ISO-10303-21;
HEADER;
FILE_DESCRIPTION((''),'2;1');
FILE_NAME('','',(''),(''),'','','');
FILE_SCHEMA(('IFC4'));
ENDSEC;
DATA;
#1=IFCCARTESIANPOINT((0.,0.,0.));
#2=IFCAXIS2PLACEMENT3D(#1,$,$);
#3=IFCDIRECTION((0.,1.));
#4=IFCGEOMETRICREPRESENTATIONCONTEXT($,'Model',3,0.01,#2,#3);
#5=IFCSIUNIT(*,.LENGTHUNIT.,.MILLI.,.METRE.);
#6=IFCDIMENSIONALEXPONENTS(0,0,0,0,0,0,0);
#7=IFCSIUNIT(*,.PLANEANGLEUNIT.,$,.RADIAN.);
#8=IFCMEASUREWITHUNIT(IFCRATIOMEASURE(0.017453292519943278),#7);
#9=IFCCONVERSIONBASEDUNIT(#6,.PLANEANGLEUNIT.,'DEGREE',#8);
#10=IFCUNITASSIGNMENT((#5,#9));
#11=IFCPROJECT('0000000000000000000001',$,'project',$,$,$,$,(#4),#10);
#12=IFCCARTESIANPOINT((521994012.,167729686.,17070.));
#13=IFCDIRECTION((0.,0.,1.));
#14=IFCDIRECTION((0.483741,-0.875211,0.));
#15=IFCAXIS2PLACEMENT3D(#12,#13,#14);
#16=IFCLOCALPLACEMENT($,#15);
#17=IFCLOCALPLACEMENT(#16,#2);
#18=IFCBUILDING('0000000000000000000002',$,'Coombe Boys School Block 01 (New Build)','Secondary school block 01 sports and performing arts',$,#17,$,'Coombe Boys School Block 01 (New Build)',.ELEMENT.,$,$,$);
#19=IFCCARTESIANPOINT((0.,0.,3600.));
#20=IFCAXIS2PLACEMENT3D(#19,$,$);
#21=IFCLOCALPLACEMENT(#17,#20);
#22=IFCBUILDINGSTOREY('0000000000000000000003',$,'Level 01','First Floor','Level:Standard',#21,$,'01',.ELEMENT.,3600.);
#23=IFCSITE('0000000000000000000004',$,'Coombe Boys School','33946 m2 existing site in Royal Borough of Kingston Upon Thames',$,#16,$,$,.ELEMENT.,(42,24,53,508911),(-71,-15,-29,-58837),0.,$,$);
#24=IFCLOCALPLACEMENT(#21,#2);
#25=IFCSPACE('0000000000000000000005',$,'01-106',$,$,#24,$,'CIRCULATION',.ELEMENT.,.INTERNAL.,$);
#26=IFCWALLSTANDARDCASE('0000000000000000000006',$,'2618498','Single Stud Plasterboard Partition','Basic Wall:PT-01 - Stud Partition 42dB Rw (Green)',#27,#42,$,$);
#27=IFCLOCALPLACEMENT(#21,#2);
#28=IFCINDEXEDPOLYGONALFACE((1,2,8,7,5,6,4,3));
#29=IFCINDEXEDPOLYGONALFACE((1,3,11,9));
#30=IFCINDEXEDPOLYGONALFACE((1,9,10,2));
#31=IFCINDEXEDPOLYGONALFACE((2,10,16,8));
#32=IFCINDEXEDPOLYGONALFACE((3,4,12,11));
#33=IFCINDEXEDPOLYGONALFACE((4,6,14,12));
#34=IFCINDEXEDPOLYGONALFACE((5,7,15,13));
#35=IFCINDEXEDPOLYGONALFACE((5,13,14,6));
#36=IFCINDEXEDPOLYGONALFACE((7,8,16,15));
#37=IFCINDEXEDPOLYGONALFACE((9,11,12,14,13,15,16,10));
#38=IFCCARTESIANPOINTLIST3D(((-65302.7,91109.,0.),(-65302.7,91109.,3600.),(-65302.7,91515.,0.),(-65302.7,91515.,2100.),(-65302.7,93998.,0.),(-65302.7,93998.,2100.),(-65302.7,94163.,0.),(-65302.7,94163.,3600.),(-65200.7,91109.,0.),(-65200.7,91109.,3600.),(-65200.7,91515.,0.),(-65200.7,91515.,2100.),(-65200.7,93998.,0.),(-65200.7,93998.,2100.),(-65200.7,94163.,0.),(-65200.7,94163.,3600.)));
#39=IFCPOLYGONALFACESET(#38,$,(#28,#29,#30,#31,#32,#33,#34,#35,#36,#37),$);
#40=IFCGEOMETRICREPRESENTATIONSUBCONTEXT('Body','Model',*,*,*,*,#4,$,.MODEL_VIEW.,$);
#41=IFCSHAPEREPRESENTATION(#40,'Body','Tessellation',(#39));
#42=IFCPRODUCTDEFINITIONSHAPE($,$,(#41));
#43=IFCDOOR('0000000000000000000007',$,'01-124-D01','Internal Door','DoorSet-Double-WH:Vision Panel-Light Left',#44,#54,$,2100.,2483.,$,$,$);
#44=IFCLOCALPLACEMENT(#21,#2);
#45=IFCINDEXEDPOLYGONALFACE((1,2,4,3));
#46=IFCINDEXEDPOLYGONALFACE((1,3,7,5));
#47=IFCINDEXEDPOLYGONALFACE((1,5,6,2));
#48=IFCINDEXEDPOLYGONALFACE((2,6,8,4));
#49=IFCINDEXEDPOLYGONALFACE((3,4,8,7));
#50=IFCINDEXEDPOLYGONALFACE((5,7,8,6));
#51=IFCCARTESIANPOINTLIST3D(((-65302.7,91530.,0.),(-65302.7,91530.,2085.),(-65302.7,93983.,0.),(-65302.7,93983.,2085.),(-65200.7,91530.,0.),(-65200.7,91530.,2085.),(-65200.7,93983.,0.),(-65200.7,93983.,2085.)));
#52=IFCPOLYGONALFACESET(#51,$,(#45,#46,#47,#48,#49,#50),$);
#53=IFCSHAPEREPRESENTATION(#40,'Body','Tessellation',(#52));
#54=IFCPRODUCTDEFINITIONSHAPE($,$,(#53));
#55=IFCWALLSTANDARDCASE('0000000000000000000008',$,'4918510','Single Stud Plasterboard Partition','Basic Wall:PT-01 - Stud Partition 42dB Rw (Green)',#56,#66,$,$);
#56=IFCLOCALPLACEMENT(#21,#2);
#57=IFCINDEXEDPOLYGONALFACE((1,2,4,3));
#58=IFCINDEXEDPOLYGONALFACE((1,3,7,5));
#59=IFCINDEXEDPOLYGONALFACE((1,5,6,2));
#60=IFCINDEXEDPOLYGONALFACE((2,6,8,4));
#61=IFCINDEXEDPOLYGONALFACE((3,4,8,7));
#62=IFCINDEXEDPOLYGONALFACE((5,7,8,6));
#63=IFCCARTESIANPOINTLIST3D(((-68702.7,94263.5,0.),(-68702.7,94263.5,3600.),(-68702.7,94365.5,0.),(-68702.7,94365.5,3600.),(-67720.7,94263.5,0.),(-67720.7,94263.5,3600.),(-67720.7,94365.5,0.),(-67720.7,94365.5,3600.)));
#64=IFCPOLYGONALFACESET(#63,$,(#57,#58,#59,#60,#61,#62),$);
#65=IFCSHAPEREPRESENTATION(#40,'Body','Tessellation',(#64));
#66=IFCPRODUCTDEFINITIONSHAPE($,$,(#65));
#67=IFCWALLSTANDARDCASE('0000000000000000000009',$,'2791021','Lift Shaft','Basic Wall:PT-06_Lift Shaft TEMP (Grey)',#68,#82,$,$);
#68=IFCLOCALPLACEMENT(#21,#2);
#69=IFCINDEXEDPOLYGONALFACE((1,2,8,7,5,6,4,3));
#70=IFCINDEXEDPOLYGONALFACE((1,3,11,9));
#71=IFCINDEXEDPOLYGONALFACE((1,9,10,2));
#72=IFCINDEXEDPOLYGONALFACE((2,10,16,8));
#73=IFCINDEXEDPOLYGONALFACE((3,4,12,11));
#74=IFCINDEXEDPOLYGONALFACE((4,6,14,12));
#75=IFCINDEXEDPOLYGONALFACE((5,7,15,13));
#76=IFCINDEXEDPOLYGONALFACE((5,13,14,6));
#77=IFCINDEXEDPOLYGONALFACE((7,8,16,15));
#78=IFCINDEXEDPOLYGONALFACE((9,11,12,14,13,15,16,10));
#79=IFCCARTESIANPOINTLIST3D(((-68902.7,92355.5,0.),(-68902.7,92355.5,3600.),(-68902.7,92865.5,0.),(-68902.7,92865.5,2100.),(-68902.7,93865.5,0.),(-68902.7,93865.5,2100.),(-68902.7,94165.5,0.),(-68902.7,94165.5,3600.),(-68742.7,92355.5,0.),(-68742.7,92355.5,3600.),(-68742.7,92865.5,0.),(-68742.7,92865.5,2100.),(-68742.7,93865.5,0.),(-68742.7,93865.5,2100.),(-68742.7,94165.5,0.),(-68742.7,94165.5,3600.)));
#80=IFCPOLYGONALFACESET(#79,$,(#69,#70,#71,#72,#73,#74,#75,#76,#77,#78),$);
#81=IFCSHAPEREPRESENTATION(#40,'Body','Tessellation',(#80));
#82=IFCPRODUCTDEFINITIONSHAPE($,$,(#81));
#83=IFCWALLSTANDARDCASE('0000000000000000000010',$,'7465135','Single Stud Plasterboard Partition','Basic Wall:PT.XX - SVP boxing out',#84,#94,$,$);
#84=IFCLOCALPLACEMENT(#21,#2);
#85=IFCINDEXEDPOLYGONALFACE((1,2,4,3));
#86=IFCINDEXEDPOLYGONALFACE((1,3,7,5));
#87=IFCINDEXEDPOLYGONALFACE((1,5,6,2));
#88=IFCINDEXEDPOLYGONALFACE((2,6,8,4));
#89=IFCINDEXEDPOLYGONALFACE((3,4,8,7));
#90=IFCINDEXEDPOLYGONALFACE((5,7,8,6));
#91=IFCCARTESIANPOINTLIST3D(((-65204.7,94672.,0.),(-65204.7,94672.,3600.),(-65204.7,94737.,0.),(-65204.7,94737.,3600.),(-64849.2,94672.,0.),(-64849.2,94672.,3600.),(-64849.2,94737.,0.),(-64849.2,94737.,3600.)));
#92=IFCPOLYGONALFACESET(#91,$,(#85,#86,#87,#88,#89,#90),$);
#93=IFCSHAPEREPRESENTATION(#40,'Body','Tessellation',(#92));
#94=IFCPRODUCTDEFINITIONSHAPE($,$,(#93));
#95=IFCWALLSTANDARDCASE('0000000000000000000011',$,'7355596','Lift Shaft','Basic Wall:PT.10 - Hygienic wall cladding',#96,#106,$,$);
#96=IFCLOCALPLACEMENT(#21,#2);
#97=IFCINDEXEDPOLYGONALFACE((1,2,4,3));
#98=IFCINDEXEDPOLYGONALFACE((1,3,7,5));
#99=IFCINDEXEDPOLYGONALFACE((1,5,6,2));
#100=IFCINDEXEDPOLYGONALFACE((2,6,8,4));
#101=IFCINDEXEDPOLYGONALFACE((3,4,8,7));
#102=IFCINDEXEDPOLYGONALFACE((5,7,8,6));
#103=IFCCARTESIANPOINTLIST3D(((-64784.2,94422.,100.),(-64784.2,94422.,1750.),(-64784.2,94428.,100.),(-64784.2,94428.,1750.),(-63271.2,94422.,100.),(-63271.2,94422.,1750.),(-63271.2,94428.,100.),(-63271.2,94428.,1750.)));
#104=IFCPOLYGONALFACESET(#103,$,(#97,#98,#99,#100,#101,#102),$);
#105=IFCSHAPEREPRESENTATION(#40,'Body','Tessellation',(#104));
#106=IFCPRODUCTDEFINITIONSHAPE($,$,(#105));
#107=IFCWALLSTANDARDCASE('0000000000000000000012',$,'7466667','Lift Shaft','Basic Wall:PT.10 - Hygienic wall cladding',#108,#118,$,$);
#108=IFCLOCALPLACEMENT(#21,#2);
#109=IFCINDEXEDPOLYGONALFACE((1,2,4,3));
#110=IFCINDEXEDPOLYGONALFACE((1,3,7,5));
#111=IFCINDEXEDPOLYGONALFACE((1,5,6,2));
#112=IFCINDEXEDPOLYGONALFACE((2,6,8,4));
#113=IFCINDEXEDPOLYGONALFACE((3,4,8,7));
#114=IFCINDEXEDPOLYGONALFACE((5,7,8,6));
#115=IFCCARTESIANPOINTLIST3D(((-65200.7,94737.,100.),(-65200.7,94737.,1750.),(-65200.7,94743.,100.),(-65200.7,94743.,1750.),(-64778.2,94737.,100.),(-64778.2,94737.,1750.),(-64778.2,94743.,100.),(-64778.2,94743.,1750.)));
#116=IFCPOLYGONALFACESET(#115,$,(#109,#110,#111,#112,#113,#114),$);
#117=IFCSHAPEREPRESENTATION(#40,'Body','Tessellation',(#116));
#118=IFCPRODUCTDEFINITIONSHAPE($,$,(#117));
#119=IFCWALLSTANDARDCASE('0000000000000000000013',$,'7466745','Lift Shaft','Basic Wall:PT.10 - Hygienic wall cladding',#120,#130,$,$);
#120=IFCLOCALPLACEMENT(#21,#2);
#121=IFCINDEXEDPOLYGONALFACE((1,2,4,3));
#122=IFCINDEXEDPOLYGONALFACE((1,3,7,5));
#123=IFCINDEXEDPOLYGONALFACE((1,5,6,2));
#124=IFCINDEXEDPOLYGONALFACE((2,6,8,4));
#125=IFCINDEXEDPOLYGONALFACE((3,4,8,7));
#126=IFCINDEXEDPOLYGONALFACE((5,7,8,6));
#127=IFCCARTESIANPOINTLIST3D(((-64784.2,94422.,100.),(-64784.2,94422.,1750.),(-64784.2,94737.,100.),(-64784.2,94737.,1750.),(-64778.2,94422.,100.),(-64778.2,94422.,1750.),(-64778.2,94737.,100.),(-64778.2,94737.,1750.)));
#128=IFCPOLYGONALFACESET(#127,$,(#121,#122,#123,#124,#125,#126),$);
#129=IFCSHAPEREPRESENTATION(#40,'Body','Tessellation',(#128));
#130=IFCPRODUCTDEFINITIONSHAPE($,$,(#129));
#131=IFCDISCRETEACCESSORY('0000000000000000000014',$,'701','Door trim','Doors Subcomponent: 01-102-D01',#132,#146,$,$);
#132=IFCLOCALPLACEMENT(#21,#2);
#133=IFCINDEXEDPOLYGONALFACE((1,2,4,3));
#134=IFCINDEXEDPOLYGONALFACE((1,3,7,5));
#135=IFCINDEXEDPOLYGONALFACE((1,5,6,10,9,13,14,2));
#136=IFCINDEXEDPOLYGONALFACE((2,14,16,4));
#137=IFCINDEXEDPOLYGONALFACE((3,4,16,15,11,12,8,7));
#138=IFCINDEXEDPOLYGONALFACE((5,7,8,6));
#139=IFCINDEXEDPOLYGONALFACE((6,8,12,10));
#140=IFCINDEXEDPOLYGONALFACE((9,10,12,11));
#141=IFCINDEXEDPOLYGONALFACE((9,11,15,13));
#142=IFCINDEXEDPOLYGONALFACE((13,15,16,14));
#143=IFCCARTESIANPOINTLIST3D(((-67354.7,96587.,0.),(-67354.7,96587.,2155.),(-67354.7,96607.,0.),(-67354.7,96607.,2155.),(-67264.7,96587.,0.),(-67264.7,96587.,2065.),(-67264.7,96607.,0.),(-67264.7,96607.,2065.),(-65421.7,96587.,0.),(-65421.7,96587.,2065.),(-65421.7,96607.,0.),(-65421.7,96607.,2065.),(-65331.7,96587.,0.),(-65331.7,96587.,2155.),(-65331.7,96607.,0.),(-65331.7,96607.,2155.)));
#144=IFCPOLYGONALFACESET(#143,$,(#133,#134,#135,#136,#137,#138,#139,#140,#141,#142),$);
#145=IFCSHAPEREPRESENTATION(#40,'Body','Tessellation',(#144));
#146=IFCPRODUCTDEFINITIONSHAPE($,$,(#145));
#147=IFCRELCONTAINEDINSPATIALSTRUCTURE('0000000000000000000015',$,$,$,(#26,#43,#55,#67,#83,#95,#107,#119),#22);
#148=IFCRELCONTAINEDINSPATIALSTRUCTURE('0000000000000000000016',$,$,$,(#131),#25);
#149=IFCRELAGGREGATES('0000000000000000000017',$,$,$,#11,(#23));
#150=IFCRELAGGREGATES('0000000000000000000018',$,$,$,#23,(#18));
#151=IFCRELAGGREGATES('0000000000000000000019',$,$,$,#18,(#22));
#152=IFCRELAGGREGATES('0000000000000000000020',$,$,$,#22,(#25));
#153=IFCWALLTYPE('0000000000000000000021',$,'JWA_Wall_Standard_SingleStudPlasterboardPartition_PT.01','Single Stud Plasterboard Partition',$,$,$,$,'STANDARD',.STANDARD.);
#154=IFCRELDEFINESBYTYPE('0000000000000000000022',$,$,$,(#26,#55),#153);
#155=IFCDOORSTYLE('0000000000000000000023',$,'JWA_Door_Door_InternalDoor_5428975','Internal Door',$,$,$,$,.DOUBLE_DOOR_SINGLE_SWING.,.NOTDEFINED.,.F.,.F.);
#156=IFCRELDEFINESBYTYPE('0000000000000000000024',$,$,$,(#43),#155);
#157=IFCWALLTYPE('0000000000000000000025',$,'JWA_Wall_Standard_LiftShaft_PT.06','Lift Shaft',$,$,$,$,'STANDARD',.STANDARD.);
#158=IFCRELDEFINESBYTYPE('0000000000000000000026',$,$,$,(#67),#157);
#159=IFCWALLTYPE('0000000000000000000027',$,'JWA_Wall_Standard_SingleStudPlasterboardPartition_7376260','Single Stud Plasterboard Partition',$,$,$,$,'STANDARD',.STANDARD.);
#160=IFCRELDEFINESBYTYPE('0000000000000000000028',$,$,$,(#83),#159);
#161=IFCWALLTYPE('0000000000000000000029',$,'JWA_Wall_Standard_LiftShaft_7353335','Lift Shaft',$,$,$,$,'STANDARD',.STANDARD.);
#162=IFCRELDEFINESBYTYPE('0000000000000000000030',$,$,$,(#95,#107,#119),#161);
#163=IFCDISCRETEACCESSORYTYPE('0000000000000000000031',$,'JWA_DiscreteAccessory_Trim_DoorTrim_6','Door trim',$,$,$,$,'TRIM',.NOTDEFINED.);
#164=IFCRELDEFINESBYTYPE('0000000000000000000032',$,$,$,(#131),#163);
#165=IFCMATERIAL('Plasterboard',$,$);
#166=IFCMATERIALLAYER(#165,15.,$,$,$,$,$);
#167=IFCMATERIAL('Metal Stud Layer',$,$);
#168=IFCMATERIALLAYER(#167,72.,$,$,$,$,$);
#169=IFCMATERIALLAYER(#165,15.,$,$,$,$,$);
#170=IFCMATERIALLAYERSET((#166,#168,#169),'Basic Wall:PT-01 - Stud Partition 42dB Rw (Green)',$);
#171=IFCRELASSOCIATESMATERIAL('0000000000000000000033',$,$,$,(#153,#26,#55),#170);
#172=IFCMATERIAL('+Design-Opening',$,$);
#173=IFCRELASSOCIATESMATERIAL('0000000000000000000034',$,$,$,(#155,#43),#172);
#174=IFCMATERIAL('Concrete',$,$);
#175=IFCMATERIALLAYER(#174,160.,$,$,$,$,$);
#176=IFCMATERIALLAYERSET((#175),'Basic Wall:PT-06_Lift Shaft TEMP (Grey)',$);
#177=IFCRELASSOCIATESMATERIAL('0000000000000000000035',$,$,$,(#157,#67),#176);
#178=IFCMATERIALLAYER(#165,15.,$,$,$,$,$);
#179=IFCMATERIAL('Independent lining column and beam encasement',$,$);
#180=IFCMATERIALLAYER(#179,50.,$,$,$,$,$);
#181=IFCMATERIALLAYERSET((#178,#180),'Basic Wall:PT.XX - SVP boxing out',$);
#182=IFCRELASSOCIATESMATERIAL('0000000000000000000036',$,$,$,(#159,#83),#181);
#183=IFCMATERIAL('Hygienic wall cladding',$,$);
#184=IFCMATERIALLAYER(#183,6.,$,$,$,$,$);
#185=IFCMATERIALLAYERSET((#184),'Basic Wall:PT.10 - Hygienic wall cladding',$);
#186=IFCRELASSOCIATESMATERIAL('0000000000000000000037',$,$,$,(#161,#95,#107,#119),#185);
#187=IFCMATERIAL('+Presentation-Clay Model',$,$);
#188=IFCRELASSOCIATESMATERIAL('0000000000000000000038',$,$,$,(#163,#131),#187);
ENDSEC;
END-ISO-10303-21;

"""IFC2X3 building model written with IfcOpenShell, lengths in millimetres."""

from ifc_helpers import new_model, entity, si_unit, converted_unit, direction, frame, frame_2d, origin, origin_2d_with_axis, place, context, subcontext, project, spatial, polyline, rectangle, outline, extrude, source, transform, mapped, material, layer, layer_set, layer_usage, type_object, type_shapes, element, fill, save


model = new_model("IFC2X3")

# Units and contexts
model_context = context("Model", 3, precision=0.01, world=origin(), true_north=direction((0.0, 1.0)))
body_context = subcontext(model_context, "Body", "Model", "MODEL_VIEW")
ifc_project = project(units=[si_unit("LENGTHUNIT", "METRE", prefix="MILLI"), converted_unit("PLANEANGLEUNIT", "DEGREE", entity("IfcRatioMeasure", 0.017453292519943278), si_unit("PLANEANGLEUNIT", "RADIAN"), dimensions=[0, 0, 0, 0, 0, 0, 0])], contexts=[model_context])

# Site, building, storey
site_placement = place(None, frame((521994012.0, 167729686.0, 17070.0), z_axis=(0.0, 0.0, 1.0), x_axis=(0.483741, -0.875211, 0.0)))
site = spatial("IfcSite", under=ifc_project, at=site_placement, Name="Coombe Boys School", Description="33946 m2 existing site in Royal Borough of Kingston Upon Thames", CompositionType="ELEMENT", RefLatitude=(42, 24, 53, 508911), RefLongitude=(-71, -15, -29, -58837), RefElevation=0.0)
building_placement = place(site_placement, origin())
building = spatial("IfcBuilding", under=site, at=building_placement, Name="Coombe Boys School Block 01 (New Build)", Description="Secondary school block 01 sports and performing arts", LongName="Coombe Boys School Block 01 (New Build)", CompositionType="ELEMENT")
storey_placement = place(building_placement, frame((0.0, 0.0, 3600.0)))
storey = spatial("IfcBuildingStorey", under=building, at=storey_placement, Name="Level 01", Description="First Floor", ObjectType="Level:Standard", LongName="01", CompositionType="ELEMENT", Elevation=3600.0)

# Wall, opening, door
ifc_material_1 = material(Name="Plasterboard")
ifc_layer_1 = layer(ifc_material_1, 15.0)
ifc_material_2 = material(Name="Metal Stud Layer")
ifc_layer_2 = layer(ifc_material_2, 72.0)
ifc_layer_3 = layer(ifc_material_1, 15.0)
ifc_layer_set_1 = layer_set([ifc_layer_1, ifc_layer_2, ifc_layer_3], Name="Basic Wall:PT-01 - Stud Partition 42dB Rw (Green)")
ifc_layer_usage_1 = layer_usage(ifc_layer_set_1, "AXIS2", "NEGATIVE", 51.0)
wall_type_1 = type_object("IfcWallType", Name="JWA_Wall_Standard_SingleStudPlasterboardPartition_PT.01", Description="Single Stud Plasterboard Partition", ElementType="STANDARD", PredefinedType="STANDARD", material=ifc_layer_set_1)
wall_1_placement = place(storey_placement, frame((-65251.7, 94163.0, 0.0), z_axis=(0.0, 0.0, 1.0), x_axis=(0.0, -1.0, 0.0)))
wall_1 = element("IfcWallStandardCase", 1, at=wall_1_placement, inside=storey, type_object=wall_type_1, material=ifc_layer_usage_1, Name="2618498", Description="Single Stud Plasterboard Partition", ObjectType="Basic Wall:PT-01 - Stud Partition 42dB Rw (Green)", context=body_context, shape_type="SweptSolid", body=[
    extrude(rectangle(XDim=3054.0, YDim=102.0, at=frame_2d((1527.0, 0.0), x_axis=(1.0, 0.0))), origin(), (0.0, 0.0, 1.0), 3600.0),
])
opening_1_placement = place(wall_1_placement, frame((94163.0, 65251.7, 0.0), z_axis=(0.0, 0.0, 1.0), x_axis=(0.0, 1.0, 0.0)))
opening_1 = element("IfcOpeningElement", 2, at=opening_1_placement, cuts=wall_1, ObjectType="Opening", context=body_context, shape_type="SweptSolid", body=[
    extrude(rectangle(XDim=2100.0, YDim=2483.0, at=frame_2d((0.0, 0.0), x_axis=(0.0, 1.0))), frame((-65302.7, 92756.5, 1050.0), z_axis=(1.0, 0.0, 0.0), x_axis=(0.0, -1.0, 0.0)), (0.0, 0.0, 1.0), 102.0),
])
ifc_material_3 = material(Name="+Design-Opening")
door_style = type_object("IfcDoorStyle", Name="JWA_Door_Door_InternalDoor_5428975", Description="Internal Door", ConstructionType="NOTDEFINED", OperationType="DOUBLE_DOOR_SINGLE_SWING", ParameterTakesPrecedence=False, Sizeable=False, material=ifc_material_3)
shared_shape_1 = source(origin(), body_context, "Body", "SweptSolid", [
    extrude(rectangle(XDim=2453.0, YDim=102.0, at=frame_2d((0.0, 0.0), x_axis=(1.0, 0.0))), frame((-160.0, 0.0, 0.0), z_axis=(0.0, 0.0, 1.0), x_axis=(-1.0, 0.0, 0.0)), (0.0, 0.0, 1.0), 2085.0),
])
type_shapes(door_style, [shared_shape_1])
door_placement = place(opening_1_placement, frame((-65251.7, 92916.5, 0.0), z_axis=(0.0, 0.0, 1.0), x_axis=(0.0, 1.0, 0.0)))
door = element("IfcDoor", 3, at=door_placement, inside=storey, type_object=door_style, material=ifc_material_3, Name="01-124-D01", Description="Internal Door", ObjectType="DoorSet-Double-WH:Vision Panel-Light Left", OverallHeight=2100.0, OverallWidth=2483.0, context=body_context, shape_type="MappedRepresentation", body=[
    mapped(shared_shape_1, transform((0.0, 0.0, 0.0), scale=1.0)),
])
fill(opening_1, door)

# Wall
wall_2_placement = place(storey_placement, frame((-68702.7, 94314.5, 0.0)))
element("IfcWallStandardCase", 4, at=wall_2_placement, inside=storey, type_object=wall_type_1, material=ifc_layer_usage_1, Name="4918510", Description="Single Stud Plasterboard Partition", ObjectType="Basic Wall:PT-01 - Stud Partition 42dB Rw (Green)", context=body_context, shape_type="SweptSolid", body=[
    extrude(rectangle(XDim=982.0, YDim=102.0, at=frame_2d((491.0, 0.0), x_axis=(-1.0, 0.0))), origin(), (0.0, 0.0, 1.0), 3600.0),
])

# Wall, opening
ifc_material_4 = material(Name="Concrete")
ifc_layer_4 = layer(ifc_material_4, 160.0)
ifc_layer_set_2 = layer_set([ifc_layer_4], Name="Basic Wall:PT-06_Lift Shaft TEMP (Grey)")
ifc_layer_usage_2 = layer_usage(ifc_layer_set_2, "AXIS2", "NEGATIVE", 80.0)
wall_type_2 = type_object("IfcWallType", Name="JWA_Wall_Standard_LiftShaft_PT.06", Description="Lift Shaft", ElementType="STANDARD", PredefinedType="STANDARD", material=ifc_layer_set_2)
wall_3_placement = place(storey_placement, frame((-68822.7, 94165.5, 0.0), z_axis=(0.0, 0.0, 1.0), x_axis=(0.0, -1.0, 0.0)))
wall_3 = element("IfcWallStandardCase", 5, at=wall_3_placement, inside=storey, type_object=wall_type_2, material=ifc_layer_usage_2, Name="2791021", Description="Lift Shaft", ObjectType="Basic Wall:PT-06_Lift Shaft TEMP (Grey)", context=body_context, shape_type="SweptSolid", body=[
    extrude(rectangle(XDim=1810.0, YDim=160.0, at=frame_2d((905.0, 0.0), x_axis=(1.0, 0.0))), origin(), (0.0, 0.0, 1.0), 3600.0),
])
opening_2_placement = place(wall_3_placement, frame((1300.0, 80.0, 0.0)))
element("IfcOpeningElement", 6, at=opening_2_placement, cuts=wall_3, ObjectType="Opening", context=body_context, shape_type="SweptSolid", body=[
    extrude(rectangle(XDim=2100.0, YDim=1000.0, at=frame_2d((1050.0, 500.0), x_axis=(1.0, 0.0))), frame((0.0, 0.0, 0.0), z_axis=(0.0, -1.0, 0.0), x_axis=(0.0, 0.0, 1.0)), (0.0, 0.0, 1.0), 160.0),
])

# Walls
ifc_layer_5 = layer(ifc_material_1, 15.0)
ifc_material_5 = material(Name="Independent lining column and beam encasement")
ifc_layer_6 = layer(ifc_material_5, 50.0)
ifc_layer_set_3 = layer_set([ifc_layer_5, ifc_layer_6], Name="Basic Wall:PT.XX - SVP boxing out")
ifc_layer_usage_3 = layer_usage(ifc_layer_set_3, "AXIS2", "POSITIVE", -32.5)
wall_type_3 = type_object("IfcWallType", Name="JWA_Wall_Standard_SingleStudPlasterboardPartition_7376260", Description="Single Stud Plasterboard Partition", ElementType="STANDARD", PredefinedType="STANDARD", material=ifc_layer_set_3)
wall_4_placement = place(storey_placement, frame((-64849.2, 94704.5, 0.0), z_axis=(0.0, 0.0, 1.0), x_axis=(-1.0, 0.0, 0.0)))
element("IfcWallStandardCase", 7, at=wall_4_placement, inside=storey, type_object=wall_type_3, material=ifc_layer_usage_3, Name="7465135", Description="Single Stud Plasterboard Partition", ObjectType="Basic Wall:PT.XX - SVP boxing out", context=body_context, shape_type="SweptSolid", body=[
    extrude(rectangle(XDim=65.0, YDim=355.5, at=frame_2d((0.0, 0.0), x_axis=(1.0, 0.0))), frame((177.7, 0.0, 0.0), z_axis=(0.0, 0.0, 1.0), x_axis=(0.0, 1.0, 0.0)), (0.0, 0.0, 1.0), 3600.0),
])
ifc_material_6 = material(Name="Hygienic wall cladding")
ifc_layer_7 = layer(ifc_material_6, 6.0)
ifc_layer_set_4 = layer_set([ifc_layer_7], Name="Basic Wall:PT.10 - Hygienic wall cladding")
ifc_layer_usage_4 = layer_usage(ifc_layer_set_4, "AXIS2", "NEGATIVE", 3.0)
wall_type_4 = type_object("IfcWallType", Name="JWA_Wall_Standard_LiftShaft_7353335", Description="Lift Shaft", ElementType="STANDARD", PredefinedType="STANDARD", material=ifc_layer_set_4)
wall_5_placement = place(storey_placement, frame((-64784.2, 94425.0, 100.0)))
element("IfcWallStandardCase", 8, at=wall_5_placement, inside=storey, type_object=wall_type_4, material=ifc_layer_usage_4, Name="7355596", Description="Lift Shaft", ObjectType="Basic Wall:PT.10 - Hygienic wall cladding", context=body_context, shape_type="SweptSolid", body=[
    extrude(rectangle(XDim=6.0, YDim=1513.0, at=origin_2d_with_axis()), frame((756.5, 0.0, 0.0), z_axis=(0.0, 0.0, 1.0), x_axis=(0.0, 1.0, 0.0)), (0.0, 0.0, 1.0), 1650.0),
])
wall_6_placement = place(storey_placement, frame((-65200.7, 94740.0, 100.0)))
element("IfcWallStandardCase", 9, at=wall_6_placement, inside=storey, type_object=wall_type_4, material=ifc_layer_usage_4, Name="7466667", Description="Lift Shaft", ObjectType="Basic Wall:PT.10 - Hygienic wall cladding", context=body_context, shape_type="SweptSolid", body=[
    extrude(rectangle(XDim=422.5, YDim=6.0, at=frame_2d((211.3, 0.0), x_axis=(-1.0, 0.0))), origin(), (0.0, 0.0, 1.0), 1650.0),
])
wall_7_placement = place(storey_placement, frame((-64781.2, 94737.0, 100.0), z_axis=(0.0, 0.0, 1.0), x_axis=(0.0, -1.0, 0.0)))
element("IfcWallStandardCase", 10, at=wall_7_placement, inside=storey, type_object=wall_type_4, material=ifc_layer_usage_4, Name="7466745", Description="Lift Shaft", ObjectType="Basic Wall:PT.10 - Hygienic wall cladding", context=body_context, shape_type="SweptSolid", body=[
    extrude(rectangle(XDim=315.0, YDim=6.0, at=frame_2d((157.5, 0.0), x_axis=(-1.0, 0.0))), origin(), (0.0, 0.0, 1.0), 1650.0),
])

# Shared definitions
ifc_material_7 = material(Name="+Presentation-Clay Model")

# Shared definitions
space_1_placement = place(storey_placement, origin())
space_1 = spatial("IfcSpace", under=storey, at=space_1_placement, Name="01-106", LongName="CIRCULATION", CompositionType="ELEMENT", InteriorOrExteriorSpace="INTERNAL")

# Discrete accessory
discrete_accessory_type_1 = type_object("IfcDiscreteAccessoryType", Name="JWA_DiscreteAccessory_Trim_DoorTrim_6", Description="Door trim", ElementType="TRIM", material=ifc_material_7)
shared_shape_2 = source(origin(), body_context, "Body", "SweptSolid", [
    extrude(outline(polyline([(-1055.0, -1011.5), (1100.0, -1011.5), (1100.0, 1011.5), (-1055.0, 1011.5), (-1055.0, 921.5), (1010.0, 921.5), (1010.0, -921.5), (-1055.0, -921.5), (-1055.0, -1011.5)])), frame((0.0, -20.0, 1055.0), z_axis=(0.0, 1.0, 0.0), x_axis=(0.0, 0.0, 1.0)), (0.0, 0.0, 1.0), 20.0),
])
type_shapes(discrete_accessory_type_1, [shared_shape_2])
discrete_accessory_1_placement = place(space_1_placement, frame((-66343.2, 96587.0, 0.0), z_axis=(0.0, 0.0, 1.0), x_axis=(-1.0, 0.0, 0.0)))
element("IfcDiscreteAccessory", 11, at=discrete_accessory_1_placement, inside=space_1, type_object=discrete_accessory_type_1, material=ifc_material_7, Name="701", Description="Door trim", ObjectType="Doors Subcomponent: 01-102-D01", context=body_context, shape_type="MappedRepresentation", body=[
    mapped(shared_shape_2, transform((0.0, 0.0, 0.0), scale=1.0)),
])

save(model, "model.ifc")
